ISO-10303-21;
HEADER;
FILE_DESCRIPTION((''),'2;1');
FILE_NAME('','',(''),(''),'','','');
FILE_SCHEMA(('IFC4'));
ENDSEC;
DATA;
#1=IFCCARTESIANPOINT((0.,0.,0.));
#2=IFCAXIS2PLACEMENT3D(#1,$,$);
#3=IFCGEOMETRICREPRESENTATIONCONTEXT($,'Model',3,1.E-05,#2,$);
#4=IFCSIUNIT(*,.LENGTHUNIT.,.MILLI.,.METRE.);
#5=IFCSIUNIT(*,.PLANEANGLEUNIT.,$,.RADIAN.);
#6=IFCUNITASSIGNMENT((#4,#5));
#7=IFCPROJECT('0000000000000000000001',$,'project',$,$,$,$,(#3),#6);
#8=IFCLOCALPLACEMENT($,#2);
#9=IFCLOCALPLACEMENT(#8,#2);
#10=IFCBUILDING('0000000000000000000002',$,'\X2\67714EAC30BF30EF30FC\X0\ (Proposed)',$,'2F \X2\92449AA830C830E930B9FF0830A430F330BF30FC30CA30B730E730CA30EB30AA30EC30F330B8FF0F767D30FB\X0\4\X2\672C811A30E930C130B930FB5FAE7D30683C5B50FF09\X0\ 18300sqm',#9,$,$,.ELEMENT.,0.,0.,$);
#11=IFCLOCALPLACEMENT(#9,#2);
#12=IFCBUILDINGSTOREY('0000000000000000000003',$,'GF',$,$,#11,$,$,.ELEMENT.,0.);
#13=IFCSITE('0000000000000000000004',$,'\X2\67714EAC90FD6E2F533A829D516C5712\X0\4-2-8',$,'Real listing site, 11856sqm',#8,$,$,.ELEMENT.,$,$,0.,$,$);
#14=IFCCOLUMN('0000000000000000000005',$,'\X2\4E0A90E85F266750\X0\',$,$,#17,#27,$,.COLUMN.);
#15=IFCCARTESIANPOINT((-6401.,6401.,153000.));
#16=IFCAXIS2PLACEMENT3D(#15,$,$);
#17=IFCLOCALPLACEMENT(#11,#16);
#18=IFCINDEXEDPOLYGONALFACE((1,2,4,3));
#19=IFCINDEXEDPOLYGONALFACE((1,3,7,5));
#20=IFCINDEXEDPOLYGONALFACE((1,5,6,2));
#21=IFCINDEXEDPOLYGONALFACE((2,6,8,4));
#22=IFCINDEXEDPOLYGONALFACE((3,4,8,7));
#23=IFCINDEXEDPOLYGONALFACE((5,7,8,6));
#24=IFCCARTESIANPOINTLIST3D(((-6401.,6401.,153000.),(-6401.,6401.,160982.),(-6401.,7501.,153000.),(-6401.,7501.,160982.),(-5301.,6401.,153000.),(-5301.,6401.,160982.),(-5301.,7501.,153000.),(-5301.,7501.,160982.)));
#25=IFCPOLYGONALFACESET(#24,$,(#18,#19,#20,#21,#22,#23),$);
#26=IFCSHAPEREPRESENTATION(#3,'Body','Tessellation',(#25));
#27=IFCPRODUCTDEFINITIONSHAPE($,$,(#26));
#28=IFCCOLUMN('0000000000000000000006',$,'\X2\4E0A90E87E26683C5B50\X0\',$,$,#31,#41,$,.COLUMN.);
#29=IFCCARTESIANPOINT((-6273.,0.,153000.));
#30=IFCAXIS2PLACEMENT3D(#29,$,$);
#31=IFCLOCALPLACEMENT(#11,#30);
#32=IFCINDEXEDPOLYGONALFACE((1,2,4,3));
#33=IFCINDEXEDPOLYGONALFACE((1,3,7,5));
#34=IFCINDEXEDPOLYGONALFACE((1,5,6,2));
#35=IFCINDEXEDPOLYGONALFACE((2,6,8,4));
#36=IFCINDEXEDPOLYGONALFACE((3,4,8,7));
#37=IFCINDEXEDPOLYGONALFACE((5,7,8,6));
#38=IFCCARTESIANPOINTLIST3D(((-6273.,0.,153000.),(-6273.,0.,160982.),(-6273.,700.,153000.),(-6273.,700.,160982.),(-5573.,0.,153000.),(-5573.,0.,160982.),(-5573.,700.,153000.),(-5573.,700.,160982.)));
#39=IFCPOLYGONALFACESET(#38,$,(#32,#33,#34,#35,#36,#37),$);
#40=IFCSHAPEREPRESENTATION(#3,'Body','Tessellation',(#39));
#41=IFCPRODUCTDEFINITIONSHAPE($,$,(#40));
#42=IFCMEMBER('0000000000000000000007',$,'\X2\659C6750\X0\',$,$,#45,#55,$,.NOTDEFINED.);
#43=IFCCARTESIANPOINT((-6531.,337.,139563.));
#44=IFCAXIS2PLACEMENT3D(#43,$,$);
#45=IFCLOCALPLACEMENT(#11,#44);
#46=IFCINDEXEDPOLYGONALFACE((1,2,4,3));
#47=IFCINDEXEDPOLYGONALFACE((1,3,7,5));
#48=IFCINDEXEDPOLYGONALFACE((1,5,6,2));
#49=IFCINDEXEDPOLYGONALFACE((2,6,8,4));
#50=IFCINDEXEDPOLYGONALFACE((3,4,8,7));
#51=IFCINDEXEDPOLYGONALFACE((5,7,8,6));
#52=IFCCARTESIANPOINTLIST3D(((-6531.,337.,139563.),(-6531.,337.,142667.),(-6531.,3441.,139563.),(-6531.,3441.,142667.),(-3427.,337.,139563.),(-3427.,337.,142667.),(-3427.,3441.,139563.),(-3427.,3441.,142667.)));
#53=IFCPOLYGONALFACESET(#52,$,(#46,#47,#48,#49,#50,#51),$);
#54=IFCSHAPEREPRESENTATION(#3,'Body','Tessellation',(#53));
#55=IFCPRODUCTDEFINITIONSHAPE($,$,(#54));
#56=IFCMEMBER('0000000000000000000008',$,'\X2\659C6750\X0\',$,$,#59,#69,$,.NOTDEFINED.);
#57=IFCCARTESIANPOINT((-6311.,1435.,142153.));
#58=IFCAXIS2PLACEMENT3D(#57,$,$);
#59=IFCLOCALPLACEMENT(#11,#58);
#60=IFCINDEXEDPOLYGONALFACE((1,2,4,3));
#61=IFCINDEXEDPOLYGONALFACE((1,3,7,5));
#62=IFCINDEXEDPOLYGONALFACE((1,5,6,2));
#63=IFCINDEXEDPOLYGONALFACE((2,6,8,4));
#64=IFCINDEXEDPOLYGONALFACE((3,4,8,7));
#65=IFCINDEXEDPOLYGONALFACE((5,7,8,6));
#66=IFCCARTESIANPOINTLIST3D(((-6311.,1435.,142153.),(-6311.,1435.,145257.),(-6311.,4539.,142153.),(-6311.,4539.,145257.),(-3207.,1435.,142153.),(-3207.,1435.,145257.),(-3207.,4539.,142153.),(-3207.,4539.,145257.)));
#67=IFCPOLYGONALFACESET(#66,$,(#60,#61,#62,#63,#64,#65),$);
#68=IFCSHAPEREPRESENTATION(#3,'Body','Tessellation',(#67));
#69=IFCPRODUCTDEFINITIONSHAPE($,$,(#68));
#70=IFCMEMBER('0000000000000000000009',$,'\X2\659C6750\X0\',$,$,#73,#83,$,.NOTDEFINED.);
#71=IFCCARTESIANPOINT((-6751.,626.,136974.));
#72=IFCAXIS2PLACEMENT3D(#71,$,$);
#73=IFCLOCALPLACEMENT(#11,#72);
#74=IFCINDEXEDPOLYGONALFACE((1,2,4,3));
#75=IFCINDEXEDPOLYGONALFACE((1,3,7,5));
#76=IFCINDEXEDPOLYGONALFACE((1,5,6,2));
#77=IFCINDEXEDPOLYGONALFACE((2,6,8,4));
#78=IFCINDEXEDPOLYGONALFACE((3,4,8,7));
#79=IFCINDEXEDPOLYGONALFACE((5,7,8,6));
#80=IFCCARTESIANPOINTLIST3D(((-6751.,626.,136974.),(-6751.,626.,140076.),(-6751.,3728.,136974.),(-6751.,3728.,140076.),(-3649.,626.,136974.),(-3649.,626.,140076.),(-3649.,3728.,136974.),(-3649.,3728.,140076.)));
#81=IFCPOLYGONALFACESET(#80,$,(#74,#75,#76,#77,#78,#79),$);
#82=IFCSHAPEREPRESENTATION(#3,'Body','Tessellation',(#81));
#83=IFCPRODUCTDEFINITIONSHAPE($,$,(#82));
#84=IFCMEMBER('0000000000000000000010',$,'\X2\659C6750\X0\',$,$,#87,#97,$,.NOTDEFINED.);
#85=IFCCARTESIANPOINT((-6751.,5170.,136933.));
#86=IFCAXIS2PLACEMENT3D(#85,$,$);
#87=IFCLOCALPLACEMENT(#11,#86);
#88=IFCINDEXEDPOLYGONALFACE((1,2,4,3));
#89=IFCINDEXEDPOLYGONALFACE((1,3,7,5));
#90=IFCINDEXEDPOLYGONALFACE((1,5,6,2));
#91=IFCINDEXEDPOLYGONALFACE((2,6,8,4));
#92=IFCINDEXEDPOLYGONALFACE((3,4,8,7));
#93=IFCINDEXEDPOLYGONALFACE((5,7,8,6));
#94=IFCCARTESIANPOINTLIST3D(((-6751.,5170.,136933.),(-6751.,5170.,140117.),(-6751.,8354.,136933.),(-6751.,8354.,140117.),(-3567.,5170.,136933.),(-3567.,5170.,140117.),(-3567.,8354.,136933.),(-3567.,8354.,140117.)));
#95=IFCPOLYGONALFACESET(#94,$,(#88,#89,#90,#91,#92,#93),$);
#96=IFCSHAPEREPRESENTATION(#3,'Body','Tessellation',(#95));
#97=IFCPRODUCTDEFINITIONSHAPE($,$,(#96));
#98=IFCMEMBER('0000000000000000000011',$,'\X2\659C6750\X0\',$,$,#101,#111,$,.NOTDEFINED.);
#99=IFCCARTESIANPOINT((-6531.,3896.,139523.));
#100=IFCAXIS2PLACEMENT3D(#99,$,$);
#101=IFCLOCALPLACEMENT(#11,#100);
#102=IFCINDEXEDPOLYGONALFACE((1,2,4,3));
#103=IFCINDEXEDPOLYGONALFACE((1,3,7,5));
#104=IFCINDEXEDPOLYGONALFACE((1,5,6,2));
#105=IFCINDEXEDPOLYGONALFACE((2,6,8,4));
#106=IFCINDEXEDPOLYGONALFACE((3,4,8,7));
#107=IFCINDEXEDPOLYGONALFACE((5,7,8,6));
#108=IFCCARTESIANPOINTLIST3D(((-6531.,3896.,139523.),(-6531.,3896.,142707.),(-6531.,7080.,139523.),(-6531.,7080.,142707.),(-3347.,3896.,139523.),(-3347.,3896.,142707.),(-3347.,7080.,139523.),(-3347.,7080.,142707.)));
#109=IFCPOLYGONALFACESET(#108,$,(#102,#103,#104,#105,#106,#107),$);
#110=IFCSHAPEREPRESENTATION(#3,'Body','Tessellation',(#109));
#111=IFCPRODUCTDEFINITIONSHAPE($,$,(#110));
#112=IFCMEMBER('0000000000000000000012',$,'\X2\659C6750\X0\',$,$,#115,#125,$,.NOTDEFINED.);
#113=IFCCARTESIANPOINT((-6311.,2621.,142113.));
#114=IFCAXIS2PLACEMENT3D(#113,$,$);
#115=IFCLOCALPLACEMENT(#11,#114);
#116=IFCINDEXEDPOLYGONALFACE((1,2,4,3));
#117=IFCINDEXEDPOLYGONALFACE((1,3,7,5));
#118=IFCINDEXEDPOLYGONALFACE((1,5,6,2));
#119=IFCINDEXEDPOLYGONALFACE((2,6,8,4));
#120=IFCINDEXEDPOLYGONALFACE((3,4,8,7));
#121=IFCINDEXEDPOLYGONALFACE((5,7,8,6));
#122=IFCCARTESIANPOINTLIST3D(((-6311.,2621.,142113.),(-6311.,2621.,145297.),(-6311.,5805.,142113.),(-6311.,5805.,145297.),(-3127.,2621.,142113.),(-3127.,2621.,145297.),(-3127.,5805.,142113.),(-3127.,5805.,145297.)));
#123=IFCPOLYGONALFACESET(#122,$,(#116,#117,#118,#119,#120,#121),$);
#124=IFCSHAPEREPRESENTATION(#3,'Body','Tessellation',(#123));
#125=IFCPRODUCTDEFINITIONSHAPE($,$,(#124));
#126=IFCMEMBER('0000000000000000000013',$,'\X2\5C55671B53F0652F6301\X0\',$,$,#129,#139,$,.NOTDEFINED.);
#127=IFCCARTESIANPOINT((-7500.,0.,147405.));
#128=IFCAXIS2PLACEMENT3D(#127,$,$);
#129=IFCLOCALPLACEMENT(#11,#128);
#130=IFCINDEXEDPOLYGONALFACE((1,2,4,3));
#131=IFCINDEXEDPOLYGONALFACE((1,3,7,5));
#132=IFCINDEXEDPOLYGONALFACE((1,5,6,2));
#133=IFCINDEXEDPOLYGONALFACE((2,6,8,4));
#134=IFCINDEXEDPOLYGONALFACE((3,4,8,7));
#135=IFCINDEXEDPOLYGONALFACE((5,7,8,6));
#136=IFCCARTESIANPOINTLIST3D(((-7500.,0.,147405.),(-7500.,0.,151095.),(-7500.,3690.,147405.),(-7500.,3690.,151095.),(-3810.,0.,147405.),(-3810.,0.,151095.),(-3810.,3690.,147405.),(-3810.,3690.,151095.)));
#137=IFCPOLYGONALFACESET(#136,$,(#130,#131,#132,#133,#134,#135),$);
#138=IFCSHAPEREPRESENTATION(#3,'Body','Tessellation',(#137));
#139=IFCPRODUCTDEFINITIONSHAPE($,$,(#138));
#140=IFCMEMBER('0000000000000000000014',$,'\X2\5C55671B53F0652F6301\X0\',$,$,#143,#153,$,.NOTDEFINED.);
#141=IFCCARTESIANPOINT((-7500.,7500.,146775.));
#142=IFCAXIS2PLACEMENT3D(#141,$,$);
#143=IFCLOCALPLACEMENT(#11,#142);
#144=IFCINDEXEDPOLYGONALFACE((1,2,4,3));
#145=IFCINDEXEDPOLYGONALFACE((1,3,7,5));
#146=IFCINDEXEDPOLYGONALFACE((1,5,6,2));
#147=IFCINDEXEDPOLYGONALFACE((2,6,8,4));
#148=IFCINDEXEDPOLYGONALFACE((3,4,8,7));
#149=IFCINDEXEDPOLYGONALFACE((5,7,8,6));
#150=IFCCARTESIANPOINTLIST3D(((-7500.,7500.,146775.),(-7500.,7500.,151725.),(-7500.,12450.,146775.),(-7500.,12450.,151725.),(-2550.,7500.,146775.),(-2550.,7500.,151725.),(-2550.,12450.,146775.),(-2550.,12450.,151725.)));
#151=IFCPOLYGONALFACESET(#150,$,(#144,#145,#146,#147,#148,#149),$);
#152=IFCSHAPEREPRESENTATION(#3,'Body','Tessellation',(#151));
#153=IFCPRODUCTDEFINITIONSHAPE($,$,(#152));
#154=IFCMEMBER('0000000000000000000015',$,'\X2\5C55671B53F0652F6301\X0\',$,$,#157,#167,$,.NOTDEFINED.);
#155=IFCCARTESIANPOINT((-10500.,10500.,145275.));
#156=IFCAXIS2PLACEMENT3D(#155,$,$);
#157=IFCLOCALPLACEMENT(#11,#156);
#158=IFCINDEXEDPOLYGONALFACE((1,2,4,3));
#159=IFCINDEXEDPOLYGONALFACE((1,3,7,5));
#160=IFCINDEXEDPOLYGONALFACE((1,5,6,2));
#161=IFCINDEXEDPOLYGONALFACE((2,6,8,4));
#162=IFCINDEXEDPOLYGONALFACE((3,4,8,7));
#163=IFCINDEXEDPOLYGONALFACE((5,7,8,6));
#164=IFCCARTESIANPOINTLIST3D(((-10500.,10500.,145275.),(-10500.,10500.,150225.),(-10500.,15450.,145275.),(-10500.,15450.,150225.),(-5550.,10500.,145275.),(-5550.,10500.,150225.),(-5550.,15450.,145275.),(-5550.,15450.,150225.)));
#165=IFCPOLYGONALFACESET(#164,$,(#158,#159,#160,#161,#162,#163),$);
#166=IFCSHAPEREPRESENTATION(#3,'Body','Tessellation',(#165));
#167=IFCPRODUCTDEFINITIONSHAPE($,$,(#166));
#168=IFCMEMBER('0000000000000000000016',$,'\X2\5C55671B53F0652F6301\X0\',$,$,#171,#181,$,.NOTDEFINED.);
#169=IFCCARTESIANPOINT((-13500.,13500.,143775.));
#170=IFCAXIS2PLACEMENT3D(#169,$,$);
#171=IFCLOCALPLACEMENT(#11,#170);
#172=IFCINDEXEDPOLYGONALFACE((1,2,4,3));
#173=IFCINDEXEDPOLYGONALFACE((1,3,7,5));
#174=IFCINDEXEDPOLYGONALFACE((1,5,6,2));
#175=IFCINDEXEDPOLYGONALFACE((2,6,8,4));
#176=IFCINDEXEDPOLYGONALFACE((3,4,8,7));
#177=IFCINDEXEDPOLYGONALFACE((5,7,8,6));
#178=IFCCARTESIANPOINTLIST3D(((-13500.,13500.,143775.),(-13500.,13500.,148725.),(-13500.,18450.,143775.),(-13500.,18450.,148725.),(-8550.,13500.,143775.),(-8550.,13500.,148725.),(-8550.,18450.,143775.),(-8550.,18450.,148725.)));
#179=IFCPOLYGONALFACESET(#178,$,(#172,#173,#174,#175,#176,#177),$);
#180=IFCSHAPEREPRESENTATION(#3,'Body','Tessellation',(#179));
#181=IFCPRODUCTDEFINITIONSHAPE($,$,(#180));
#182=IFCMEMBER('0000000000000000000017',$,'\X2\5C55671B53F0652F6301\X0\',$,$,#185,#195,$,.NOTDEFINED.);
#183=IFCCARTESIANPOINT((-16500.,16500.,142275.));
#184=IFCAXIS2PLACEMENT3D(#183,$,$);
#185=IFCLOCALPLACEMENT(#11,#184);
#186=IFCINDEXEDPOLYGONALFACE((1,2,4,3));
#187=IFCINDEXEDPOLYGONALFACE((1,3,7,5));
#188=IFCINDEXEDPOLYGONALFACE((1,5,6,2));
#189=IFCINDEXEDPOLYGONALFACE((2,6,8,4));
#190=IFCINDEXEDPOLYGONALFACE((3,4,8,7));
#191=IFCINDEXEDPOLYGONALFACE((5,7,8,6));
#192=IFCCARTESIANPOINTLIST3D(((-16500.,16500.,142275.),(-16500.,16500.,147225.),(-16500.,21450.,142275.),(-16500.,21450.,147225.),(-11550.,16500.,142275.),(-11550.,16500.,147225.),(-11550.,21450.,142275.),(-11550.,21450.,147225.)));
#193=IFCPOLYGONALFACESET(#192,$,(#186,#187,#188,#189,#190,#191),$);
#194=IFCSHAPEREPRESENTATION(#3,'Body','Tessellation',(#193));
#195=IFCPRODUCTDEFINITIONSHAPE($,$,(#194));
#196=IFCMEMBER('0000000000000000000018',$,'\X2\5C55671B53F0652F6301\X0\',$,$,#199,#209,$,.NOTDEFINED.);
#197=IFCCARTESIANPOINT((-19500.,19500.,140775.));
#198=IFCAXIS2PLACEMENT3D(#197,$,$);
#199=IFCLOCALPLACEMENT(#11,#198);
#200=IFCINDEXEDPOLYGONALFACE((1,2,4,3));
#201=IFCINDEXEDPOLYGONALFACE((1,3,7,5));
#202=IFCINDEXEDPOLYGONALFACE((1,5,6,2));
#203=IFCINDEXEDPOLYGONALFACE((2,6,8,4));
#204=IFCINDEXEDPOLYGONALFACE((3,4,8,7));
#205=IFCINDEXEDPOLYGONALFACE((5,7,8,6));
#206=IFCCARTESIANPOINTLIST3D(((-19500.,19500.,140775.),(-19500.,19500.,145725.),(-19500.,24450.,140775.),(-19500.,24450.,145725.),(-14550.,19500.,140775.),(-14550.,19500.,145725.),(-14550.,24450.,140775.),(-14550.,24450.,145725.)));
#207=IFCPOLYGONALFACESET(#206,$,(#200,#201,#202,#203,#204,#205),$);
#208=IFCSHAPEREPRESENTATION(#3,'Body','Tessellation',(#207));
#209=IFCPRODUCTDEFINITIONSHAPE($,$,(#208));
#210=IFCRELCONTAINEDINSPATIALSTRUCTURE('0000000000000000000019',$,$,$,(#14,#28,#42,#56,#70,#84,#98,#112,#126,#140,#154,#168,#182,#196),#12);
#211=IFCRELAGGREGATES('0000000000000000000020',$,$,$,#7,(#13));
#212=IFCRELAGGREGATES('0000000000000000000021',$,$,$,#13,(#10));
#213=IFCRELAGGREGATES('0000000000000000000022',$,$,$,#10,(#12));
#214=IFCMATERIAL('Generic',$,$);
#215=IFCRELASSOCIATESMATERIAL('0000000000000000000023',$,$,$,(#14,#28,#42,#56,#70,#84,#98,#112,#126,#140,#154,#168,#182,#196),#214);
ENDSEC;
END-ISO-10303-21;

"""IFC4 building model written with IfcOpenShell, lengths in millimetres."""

from ifc_helpers import new_model, si_unit, frame, frame_2d, origin, place, context, project, spatial, rectangle, extrude, material, element, save


model = new_model("IFC4")

# Units and contexts
model_context = context("Model", 3, precision=1e-05, world=origin())
ifc_project = project(units=[si_unit("LENGTHUNIT", "METRE", prefix="MILLI"), si_unit("PLANEANGLEUNIT", "RADIAN")], contexts=[model_context])

# Site, building, storey
site_placement = place(None, origin())
site = spatial("IfcSite", under=ifc_project, at=site_placement, Name="東京都港区芝公園4-2-8", ObjectType="Real listing site, 11856sqm", CompositionType="ELEMENT", RefElevation=0.0)
building_placement = place(site_placement, origin())
building = spatial("IfcBuilding", under=site, at=building_placement, Name="東京タワー (Proposed)", ObjectType="2F 鉄骨トラス（インターナショナルオレンジ／白・4本脚ラチス・微細格子） 18300sqm", CompositionType="ELEMENT", ElevationOfRefHeight=0.0, ElevationOfTerrain=0.0)
storey_placement = place(building_placement, origin())
storey = spatial("IfcBuildingStorey", under=building, at=storey_placement, Name="GF", CompositionType="ELEMENT", Elevation=0.0)

# Columns
ifc_material = material(Name="Generic")
column_1_placement = place(storey_placement, frame((-6401.0, 6401.0, 153000.0)))
element("IfcColumn", 1, at=column_1_placement, inside=storey, material=ifc_material, Name="上部弦材", PredefinedType="COLUMN", context=model_context, shape_type="SweptSolid", body=[
    extrude(rectangle(XDim=1100.0, YDim=1100.0, at=frame_2d((550.0, 550.0))), frame((-6401.0, 6401.0, 153000.0)), (0.0, 0.0, 1.0), 7982.0),
])
column_2_placement = place(storey_placement, frame((-6273.0, 0.0, 153000.0)))
element("IfcColumn", 2, at=column_2_placement, inside=storey, material=ifc_material, Name="上部縦格子", PredefinedType="COLUMN", context=model_context, shape_type="SweptSolid", body=[
    extrude(rectangle(XDim=700.0, YDim=700.0, at=frame_2d((350.0, 350.0))), frame((-6273.0, 0.0, 153000.0)), (0.0, 0.0, 1.0), 7982.0),
])

# Members
member_1_placement = place(storey_placement, frame((-6531.0, 337.0, 139563.0)))
element("IfcMember", 3, at=member_1_placement, inside=storey, material=ifc_material, Name="斜材", PredefinedType="NOTDEFINED", context=model_context, shape_type="SweptSolid", body=[
    extrude(rectangle(XDim=3104.0, YDim=3104.0, at=frame_2d((1552.0, 1552.0))), frame((-6531.0, 337.0, 139563.0)), (0.0, 0.0, 1.0), 3104.0),
])
member_2_placement = place(storey_placement, frame((-6311.0, 1435.0, 142153.0)))
element("IfcMember", 4, at=member_2_placement, inside=storey, material=ifc_material, Name="斜材", PredefinedType="NOTDEFINED", context=model_context, shape_type="SweptSolid", body=[
    extrude(rectangle(XDim=3104.0, YDim=3104.0, at=frame_2d((1552.0, 1552.0))), frame((-6311.0, 1435.0, 142153.0)), (0.0, 0.0, 1.0), 3104.0),
])
member_3_placement = place(storey_placement, frame((-6751.0, 626.0, 136974.0)))
element("IfcMember", 5, at=member_3_placement, inside=storey, material=ifc_material, Name="斜材", PredefinedType="NOTDEFINED", context=model_context, shape_type="SweptSolid", body=[
    extrude(rectangle(XDim=3102.0, YDim=3102.0, at=frame_2d((1551.0, 1551.0))), frame((-6751.0, 626.0, 136974.0)), (0.0, 0.0, 1.0), 3102.0),
])
member_4_placement = place(storey_placement, frame((-6751.0, 5170.0, 136933.0)))
element("IfcMember", 6, at=member_4_placement, inside=storey, material=ifc_material, Name="斜材", PredefinedType="NOTDEFINED", context=model_context, shape_type="SweptSolid", body=[
    extrude(rectangle(XDim=3184.0, YDim=3184.0, at=frame_2d((1592.0, 1592.0))), frame((-6751.0, 5170.0, 136933.0)), (0.0, 0.0, 1.0), 3184.0),
])
member_5_placement = place(storey_placement, frame((-6531.0, 3896.0, 139523.0)))
element("IfcMember", 7, at=member_5_placement, inside=storey, material=ifc_material, Name="斜材", PredefinedType="NOTDEFINED", context=model_context, shape_type="SweptSolid", body=[
    extrude(rectangle(XDim=3184.0, YDim=3184.0, at=frame_2d((1592.0, 1592.0))), frame((-6531.0, 3896.0, 139523.0)), (0.0, 0.0, 1.0), 3184.0),
])
member_6_placement = place(storey_placement, frame((-6311.0, 2621.0, 142113.0)))
element("IfcMember", 8, at=member_6_placement, inside=storey, material=ifc_material, Name="斜材", PredefinedType="NOTDEFINED", context=model_context, shape_type="SweptSolid", body=[
    extrude(rectangle(XDim=3184.0, YDim=3184.0, at=frame_2d((1592.0, 1592.0))), frame((-6311.0, 2621.0, 142113.0)), (0.0, 0.0, 1.0), 3184.0),
])
member_7_placement = place(storey_placement, frame((-7500.0, 0.0, 147405.0)))
element("IfcMember", 9, at=member_7_placement, inside=storey, material=ifc_material, Name="展望台支持", PredefinedType="NOTDEFINED", context=model_context, shape_type="SweptSolid", body=[
    extrude(rectangle(XDim=3690.0, YDim=3690.0, at=frame_2d((1845.0, 1845.0))), frame((-7500.0, 0.0, 147405.0)), (0.0, 0.0, 1.0), 3690.0),
])
member_8_placement = place(storey_placement, frame((-7500.0, 7500.0, 146775.0)))
element("IfcMember", 10, at=member_8_placement, inside=storey, material=ifc_material, Name="展望台支持", PredefinedType="NOTDEFINED", context=model_context, shape_type="SweptSolid", body=[
    extrude(rectangle(XDim=4950.0, YDim=4950.0, at=frame_2d((2475.0, 2475.0))), frame((-7500.0, 7500.0, 146775.0)), (0.0, 0.0, 1.0), 4950.0),
])
member_9_placement = place(storey_placement, frame((-10500.0, 10500.0, 145275.0)))
element("IfcMember", 11, at=member_9_placement, inside=storey, material=ifc_material, Name="展望台支持", PredefinedType="NOTDEFINED", context=model_context, shape_type="SweptSolid", body=[
    extrude(rectangle(XDim=4950.0, YDim=4950.0, at=frame_2d((2475.0, 2475.0))), frame((-10500.0, 10500.0, 145275.0)), (0.0, 0.0, 1.0), 4950.0),
])
member_10_placement = place(storey_placement, frame((-13500.0, 13500.0, 143775.0)))
element("IfcMember", 12, at=member_10_placement, inside=storey, material=ifc_material, Name="展望台支持", PredefinedType="NOTDEFINED", context=model_context, shape_type="SweptSolid", body=[
    extrude(rectangle(XDim=4950.0, YDim=4950.0, at=frame_2d((2475.0, 2475.0))), frame((-13500.0, 13500.0, 143775.0)), (0.0, 0.0, 1.0), 4950.0),
])
member_11_placement = place(storey_placement, frame((-16500.0, 16500.0, 142275.0)))
element("IfcMember", 13, at=member_11_placement, inside=storey, material=ifc_material, Name="展望台支持", PredefinedType="NOTDEFINED", context=model_context, shape_type="SweptSolid", body=[
    extrude(rectangle(XDim=4950.0, YDim=4950.0, at=frame_2d((2475.0, 2475.0))), frame((-16500.0, 16500.0, 142275.0)), (0.0, 0.0, 1.0), 4950.0),
])
member_12_placement = place(storey_placement, frame((-19500.0, 19500.0, 140775.0)))
element("IfcMember", 14, at=member_12_placement, inside=storey, material=ifc_material, Name="展望台支持", PredefinedType="NOTDEFINED", context=model_context, shape_type="SweptSolid", body=[
    extrude(rectangle(XDim=4950.0, YDim=4950.0, at=frame_2d((2475.0, 2475.0))), frame((-19500.0, 19500.0, 140775.0)), (0.0, 0.0, 1.0), 4950.0),
])

save(model, "model.ifc")
